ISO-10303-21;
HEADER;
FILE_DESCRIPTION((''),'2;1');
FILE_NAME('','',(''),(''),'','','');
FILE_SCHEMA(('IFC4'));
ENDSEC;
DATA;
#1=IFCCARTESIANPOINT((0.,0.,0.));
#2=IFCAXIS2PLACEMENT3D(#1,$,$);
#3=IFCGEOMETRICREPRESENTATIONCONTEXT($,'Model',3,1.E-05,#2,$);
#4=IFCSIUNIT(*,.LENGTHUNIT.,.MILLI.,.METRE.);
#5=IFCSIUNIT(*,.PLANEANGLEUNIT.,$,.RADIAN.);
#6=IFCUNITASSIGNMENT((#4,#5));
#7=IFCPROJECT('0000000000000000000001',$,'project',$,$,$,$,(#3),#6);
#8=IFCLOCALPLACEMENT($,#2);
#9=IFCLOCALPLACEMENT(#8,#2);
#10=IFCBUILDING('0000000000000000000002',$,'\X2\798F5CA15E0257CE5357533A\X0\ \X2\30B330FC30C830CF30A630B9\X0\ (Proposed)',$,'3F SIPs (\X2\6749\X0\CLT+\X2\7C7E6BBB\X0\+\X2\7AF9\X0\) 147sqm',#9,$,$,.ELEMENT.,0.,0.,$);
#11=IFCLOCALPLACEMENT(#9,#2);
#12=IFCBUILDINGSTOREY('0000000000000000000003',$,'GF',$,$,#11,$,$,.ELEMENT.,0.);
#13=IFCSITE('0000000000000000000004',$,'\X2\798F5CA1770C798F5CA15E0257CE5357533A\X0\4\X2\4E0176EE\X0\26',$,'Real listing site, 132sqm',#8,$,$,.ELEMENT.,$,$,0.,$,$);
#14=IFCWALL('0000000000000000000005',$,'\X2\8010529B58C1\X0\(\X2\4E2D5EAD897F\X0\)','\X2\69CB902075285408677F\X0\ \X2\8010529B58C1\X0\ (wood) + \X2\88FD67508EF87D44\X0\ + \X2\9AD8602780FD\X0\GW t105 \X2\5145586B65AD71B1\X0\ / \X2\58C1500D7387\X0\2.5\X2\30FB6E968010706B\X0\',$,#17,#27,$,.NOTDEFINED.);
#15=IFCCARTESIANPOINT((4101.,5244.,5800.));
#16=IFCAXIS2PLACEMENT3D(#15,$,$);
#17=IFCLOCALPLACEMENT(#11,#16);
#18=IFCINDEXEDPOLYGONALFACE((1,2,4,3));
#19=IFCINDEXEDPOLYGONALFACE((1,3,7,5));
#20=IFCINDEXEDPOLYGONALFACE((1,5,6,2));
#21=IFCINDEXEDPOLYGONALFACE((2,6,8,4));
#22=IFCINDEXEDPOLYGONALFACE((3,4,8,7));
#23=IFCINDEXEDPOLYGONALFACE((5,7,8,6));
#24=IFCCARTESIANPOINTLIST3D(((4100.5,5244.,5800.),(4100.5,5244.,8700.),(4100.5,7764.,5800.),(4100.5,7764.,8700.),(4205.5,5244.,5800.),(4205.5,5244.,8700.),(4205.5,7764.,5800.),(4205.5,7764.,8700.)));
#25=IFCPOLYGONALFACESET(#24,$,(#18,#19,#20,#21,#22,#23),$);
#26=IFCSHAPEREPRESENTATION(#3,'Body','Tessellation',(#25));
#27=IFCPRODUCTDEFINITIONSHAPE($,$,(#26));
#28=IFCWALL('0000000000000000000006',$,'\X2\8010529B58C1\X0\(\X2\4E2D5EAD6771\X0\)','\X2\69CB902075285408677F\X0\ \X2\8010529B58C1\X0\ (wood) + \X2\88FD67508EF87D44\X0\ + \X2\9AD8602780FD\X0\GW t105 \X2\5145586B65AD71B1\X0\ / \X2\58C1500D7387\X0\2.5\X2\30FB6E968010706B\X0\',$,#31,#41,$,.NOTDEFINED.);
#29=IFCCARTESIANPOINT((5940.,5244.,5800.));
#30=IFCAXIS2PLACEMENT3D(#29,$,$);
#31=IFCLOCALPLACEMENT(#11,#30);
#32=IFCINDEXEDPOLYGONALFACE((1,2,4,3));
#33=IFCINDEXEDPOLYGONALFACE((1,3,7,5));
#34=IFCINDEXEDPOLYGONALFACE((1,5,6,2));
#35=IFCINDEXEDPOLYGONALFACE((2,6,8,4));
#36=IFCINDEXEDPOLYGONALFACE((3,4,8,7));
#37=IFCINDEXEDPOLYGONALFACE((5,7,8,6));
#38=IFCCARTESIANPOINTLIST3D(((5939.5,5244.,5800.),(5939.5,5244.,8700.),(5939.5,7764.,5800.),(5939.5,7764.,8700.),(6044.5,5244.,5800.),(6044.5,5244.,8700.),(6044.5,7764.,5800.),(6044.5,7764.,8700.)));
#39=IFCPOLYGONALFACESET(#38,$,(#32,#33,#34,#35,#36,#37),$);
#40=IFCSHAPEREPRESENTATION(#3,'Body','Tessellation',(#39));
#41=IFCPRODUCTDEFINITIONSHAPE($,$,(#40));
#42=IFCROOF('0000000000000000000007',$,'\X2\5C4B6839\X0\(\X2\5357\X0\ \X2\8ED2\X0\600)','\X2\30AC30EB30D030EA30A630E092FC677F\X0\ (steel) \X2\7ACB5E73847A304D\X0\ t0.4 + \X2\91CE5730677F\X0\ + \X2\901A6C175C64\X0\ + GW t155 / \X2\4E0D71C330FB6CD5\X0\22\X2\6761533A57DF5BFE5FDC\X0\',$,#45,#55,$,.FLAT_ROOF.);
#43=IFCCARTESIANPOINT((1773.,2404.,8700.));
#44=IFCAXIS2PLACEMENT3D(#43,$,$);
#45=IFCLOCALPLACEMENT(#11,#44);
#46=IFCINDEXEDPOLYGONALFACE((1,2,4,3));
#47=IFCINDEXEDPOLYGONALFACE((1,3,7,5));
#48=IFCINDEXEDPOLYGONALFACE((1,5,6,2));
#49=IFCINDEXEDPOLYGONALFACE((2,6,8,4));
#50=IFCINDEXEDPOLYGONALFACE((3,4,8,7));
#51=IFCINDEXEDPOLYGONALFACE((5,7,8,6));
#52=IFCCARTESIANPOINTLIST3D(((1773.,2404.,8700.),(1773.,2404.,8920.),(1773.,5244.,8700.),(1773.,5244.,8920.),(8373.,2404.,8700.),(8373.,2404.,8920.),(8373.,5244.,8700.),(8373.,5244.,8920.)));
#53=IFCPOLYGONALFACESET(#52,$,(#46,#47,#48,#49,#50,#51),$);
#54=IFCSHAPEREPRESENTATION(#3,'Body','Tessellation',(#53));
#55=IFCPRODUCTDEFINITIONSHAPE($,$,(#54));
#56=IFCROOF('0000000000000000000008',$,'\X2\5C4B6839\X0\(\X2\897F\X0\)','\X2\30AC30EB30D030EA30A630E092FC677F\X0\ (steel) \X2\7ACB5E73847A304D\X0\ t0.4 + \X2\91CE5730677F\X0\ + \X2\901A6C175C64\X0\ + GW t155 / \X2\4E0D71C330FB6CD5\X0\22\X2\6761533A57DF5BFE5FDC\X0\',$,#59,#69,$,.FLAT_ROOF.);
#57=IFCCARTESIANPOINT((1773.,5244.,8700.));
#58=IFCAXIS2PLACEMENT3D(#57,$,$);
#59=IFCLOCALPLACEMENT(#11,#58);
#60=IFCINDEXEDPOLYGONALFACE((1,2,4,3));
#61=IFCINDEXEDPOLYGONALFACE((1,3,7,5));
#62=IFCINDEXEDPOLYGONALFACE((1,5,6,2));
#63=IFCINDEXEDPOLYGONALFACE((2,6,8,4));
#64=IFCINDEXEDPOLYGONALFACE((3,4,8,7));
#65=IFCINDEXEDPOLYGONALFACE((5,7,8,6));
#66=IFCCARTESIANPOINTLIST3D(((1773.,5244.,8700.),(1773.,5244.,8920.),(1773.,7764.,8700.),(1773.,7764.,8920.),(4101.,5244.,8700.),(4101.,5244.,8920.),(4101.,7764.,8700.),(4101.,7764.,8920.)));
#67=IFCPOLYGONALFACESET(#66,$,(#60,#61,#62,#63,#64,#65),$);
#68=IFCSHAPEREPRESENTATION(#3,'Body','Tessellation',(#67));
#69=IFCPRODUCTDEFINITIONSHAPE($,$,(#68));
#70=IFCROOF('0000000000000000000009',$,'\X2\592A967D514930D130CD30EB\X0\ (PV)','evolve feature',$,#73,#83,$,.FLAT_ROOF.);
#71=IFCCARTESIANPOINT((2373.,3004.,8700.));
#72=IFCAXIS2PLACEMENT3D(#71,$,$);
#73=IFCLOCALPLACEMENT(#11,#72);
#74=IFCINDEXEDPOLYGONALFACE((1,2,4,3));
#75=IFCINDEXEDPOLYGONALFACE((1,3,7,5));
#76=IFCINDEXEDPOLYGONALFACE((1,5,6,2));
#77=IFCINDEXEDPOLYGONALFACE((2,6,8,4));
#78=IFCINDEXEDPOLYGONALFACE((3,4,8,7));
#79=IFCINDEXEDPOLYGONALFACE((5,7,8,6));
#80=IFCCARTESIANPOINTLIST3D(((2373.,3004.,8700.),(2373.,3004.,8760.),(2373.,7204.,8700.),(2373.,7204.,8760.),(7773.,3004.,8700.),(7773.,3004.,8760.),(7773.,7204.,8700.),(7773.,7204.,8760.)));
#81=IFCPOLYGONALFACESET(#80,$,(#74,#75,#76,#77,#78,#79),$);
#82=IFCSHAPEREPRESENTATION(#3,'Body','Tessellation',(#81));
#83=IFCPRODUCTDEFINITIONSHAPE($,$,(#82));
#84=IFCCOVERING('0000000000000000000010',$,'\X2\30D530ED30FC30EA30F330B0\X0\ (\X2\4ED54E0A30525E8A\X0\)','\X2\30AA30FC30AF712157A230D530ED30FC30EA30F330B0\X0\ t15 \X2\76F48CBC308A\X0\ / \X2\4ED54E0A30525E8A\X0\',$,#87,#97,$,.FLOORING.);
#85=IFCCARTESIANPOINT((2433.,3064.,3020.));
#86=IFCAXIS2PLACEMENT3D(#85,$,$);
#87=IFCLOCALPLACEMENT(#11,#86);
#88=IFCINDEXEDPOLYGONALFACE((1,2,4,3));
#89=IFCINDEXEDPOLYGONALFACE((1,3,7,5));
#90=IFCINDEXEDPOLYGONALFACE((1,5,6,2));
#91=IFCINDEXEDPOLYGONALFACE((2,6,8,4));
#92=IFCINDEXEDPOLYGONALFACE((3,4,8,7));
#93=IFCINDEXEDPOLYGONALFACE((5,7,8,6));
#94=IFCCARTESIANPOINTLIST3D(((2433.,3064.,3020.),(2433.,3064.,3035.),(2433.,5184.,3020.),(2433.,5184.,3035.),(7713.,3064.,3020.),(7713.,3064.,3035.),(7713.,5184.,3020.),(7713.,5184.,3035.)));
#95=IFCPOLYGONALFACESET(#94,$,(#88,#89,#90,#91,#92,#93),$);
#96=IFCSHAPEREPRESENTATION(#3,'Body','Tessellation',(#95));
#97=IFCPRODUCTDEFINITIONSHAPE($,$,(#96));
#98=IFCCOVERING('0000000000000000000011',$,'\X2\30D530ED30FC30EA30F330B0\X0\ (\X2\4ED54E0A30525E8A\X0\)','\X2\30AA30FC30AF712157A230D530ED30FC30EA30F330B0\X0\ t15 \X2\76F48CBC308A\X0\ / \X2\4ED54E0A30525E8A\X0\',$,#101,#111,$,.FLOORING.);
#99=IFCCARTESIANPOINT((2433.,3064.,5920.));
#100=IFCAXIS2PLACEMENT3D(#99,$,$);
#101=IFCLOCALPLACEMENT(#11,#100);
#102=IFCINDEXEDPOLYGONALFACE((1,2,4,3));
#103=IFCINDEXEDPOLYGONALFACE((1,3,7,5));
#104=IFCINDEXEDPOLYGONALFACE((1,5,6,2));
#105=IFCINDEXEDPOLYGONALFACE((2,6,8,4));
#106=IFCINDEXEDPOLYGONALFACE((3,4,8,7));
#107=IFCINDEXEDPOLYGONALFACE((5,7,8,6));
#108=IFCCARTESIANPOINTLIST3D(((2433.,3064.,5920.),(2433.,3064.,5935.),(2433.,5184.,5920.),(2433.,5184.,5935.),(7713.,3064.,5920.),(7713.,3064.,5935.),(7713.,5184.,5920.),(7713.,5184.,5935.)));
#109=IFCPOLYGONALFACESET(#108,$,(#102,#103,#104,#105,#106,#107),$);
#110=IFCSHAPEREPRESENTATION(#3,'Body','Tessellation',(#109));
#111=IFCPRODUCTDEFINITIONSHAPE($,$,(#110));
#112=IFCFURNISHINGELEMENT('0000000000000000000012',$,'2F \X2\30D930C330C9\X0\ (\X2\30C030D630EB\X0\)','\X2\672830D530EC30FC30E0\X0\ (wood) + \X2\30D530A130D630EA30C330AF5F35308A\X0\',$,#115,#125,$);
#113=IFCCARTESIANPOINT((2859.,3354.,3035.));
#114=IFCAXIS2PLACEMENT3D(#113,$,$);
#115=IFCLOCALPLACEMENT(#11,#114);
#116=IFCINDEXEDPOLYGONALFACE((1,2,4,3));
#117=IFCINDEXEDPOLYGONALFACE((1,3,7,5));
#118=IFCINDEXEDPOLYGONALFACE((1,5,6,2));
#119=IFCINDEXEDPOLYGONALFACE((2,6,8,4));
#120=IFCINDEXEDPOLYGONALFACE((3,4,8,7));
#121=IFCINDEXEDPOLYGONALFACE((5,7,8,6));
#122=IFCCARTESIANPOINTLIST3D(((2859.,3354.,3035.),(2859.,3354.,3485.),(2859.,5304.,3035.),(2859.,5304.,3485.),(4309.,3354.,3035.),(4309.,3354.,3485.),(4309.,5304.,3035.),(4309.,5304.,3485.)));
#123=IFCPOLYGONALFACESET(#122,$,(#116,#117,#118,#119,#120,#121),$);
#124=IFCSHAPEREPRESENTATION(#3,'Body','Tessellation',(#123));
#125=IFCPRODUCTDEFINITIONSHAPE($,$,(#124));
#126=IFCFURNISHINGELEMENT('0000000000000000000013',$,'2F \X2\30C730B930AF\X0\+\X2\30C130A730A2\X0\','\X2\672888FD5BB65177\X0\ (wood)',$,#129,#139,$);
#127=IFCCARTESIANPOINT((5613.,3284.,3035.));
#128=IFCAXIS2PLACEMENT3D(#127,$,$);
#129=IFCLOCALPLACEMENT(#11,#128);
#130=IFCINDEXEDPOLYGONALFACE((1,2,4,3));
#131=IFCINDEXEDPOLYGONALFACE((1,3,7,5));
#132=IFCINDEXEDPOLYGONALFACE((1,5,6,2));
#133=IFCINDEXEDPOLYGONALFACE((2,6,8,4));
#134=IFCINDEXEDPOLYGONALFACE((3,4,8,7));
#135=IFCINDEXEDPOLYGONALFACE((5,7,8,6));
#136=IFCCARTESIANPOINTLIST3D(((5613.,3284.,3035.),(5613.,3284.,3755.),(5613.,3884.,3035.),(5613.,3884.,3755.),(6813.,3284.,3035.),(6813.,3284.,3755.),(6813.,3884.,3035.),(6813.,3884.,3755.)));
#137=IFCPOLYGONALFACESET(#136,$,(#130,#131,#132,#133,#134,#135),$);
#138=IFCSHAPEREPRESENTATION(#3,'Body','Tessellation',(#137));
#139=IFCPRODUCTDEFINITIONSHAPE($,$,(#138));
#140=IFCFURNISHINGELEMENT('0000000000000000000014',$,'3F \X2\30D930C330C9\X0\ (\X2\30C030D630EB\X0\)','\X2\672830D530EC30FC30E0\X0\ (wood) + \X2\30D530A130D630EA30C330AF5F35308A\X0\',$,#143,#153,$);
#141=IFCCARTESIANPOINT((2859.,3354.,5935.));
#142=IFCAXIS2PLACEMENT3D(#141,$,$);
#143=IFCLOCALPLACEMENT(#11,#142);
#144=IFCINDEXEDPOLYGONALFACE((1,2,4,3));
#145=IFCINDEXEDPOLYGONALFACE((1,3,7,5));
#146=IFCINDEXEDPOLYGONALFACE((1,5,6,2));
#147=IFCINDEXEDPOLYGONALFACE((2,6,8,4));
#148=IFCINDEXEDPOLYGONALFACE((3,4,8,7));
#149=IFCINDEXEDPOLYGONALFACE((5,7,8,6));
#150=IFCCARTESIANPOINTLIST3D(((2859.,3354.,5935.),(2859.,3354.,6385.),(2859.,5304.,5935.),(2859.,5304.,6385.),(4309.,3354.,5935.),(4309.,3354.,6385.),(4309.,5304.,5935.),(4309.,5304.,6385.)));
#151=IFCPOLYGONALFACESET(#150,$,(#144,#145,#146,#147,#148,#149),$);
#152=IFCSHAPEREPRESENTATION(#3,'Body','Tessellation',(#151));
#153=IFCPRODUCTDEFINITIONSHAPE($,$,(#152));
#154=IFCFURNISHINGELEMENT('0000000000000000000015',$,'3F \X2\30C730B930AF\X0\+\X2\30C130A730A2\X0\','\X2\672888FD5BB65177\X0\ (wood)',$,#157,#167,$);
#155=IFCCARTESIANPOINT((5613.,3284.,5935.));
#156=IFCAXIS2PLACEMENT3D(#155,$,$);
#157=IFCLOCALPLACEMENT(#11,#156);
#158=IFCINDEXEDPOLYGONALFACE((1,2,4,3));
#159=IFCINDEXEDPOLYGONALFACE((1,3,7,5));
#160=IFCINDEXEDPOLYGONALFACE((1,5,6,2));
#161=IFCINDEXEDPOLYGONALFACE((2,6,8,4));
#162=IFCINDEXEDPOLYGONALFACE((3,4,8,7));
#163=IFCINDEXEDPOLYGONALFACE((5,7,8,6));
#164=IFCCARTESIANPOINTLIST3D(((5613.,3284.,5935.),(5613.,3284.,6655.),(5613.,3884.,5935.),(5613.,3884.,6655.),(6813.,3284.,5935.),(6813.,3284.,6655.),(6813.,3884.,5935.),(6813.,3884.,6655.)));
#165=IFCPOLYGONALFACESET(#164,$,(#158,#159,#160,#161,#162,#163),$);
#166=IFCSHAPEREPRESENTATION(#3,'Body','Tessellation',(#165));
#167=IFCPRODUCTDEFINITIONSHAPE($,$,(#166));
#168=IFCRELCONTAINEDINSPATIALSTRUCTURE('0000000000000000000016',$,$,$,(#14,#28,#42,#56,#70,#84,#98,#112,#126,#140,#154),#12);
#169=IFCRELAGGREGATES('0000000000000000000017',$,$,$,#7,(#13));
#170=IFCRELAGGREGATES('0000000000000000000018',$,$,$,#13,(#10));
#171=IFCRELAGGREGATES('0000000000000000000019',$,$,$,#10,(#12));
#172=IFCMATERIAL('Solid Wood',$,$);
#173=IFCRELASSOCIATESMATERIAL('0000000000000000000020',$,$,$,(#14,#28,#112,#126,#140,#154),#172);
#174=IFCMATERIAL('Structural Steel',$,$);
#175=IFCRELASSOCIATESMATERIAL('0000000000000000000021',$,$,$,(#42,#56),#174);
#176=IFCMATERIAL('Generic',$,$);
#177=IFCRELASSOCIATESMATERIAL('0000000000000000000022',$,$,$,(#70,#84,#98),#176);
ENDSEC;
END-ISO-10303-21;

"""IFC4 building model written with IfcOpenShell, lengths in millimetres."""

from ifc_helpers import new_model, si_unit, frame, frame_2d, origin, place, context, project, spatial, rectangle, extrude, material, element, save


model = new_model("IFC4")

# Units and contexts
model_context = context("Model", 3, precision=1e-05, world=origin())
ifc_project = project(units=[si_unit("LENGTHUNIT", "METRE", prefix="MILLI"), si_unit("PLANEANGLEUNIT", "RADIAN")], contexts=[model_context])

# Site, building, storey
site_placement = place(None, origin())
site = spatial("IfcSite", under=ifc_project, at=site_placement, Name="福岡県福岡市城南区4丁目26", ObjectType="Real listing site, 132sqm", CompositionType="ELEMENT", RefElevation=0.0)
building_placement = place(site_placement, origin())
building = spatial("IfcBuilding", under=site, at=building_placement, Name="福岡市城南区 コートハウス (Proposed)", ObjectType="3F SIPs (杉CLT+籾殻+竹) 147sqm", CompositionType="ELEMENT", ElevationOfRefHeight=0.0, ElevationOfTerrain=0.0)
storey_placement = place(building_placement, origin())
storey = spatial("IfcBuildingStorey", under=building, at=storey_placement, Name="GF", CompositionType="ELEMENT", Elevation=0.0)

# Shared definitions
ifc_material_1 = material(Name="Solid Wood")

# Walls
wall_1_placement = place(storey_placement, frame((4101.0, 5244.0, 5800.0)))
element("IfcWall", 1, at=wall_1_placement, inside=storey, material=ifc_material_1, Name="耐力壁(中庭西)", Description="構造用合板 耐力壁 (wood) + 製材軸組 + 高性能GW t105 充填断熱 / 壁倍率2.5・準耐火", PredefinedType="NOTDEFINED", context=model_context, shape_type="SweptSolid", body=[
    extrude(rectangle(XDim=105.0, YDim=2520.0, at=frame_2d((52.0, 1260.0))), frame((4101.0, 5244.0, 5800.0)), (0.0, 0.0, 1.0), 2900.0),
])
wall_2_placement = place(storey_placement, frame((5940.0, 5244.0, 5800.0)))
element("IfcWall", 2, at=wall_2_placement, inside=storey, material=ifc_material_1, Name="耐力壁(中庭東)", Description="構造用合板 耐力壁 (wood) + 製材軸組 + 高性能GW t105 充填断熱 / 壁倍率2.5・準耐火", PredefinedType="NOTDEFINED", context=model_context, shape_type="SweptSolid", body=[
    extrude(rectangle(XDim=105.0, YDim=2520.0, at=frame_2d((52.0, 1260.0))), frame((5940.0, 5244.0, 5800.0)), (0.0, 0.0, 1.0), 2900.0),
])

# Roofs
ifc_material_2 = material(Name="Structural Steel")
roof_1_placement = place(storey_placement, frame((1773.0, 2404.0, 8700.0)))
element("IfcRoof", 3, at=roof_1_placement, inside=storey, material=ifc_material_2, Name="屋根(南 軒600)", Description="ガルバリウム鋼板 (steel) 立平葺き t0.4 + 野地板 + 通気層 + GW t155 / 不燃・法22条区域対応", PredefinedType="FLAT_ROOF", context=model_context, shape_type="SweptSolid", body=[
    extrude(rectangle(XDim=6600.0, YDim=2840.0, at=frame_2d((3300.0, 1420.0))), frame((1773.0, 2404.0, 8700.0)), (0.0, 0.0, 1.0), 220.0),
])
roof_2_placement = place(storey_placement, frame((1773.0, 5244.0, 8700.0)))
element("IfcRoof", 4, at=roof_2_placement, inside=storey, material=ifc_material_2, Name="屋根(西)", Description="ガルバリウム鋼板 (steel) 立平葺き t0.4 + 野地板 + 通気層 + GW t155 / 不燃・法22条区域対応", PredefinedType="FLAT_ROOF", context=model_context, shape_type="SweptSolid", body=[
    extrude(rectangle(XDim=2328.0, YDim=2520.0, at=frame_2d((1164.0, 1260.0))), frame((1773.0, 5244.0, 8700.0)), (0.0, 0.0, 1.0), 220.0),
])
ifc_material_3 = material(Name="Generic")
roof_3_placement = place(storey_placement, frame((2373.0, 3004.0, 8700.0)))
element("IfcRoof", 5, at=roof_3_placement, inside=storey, material=ifc_material_3, Name="太陽光パネル (PV)", Description="evolve feature", PredefinedType="FLAT_ROOF", context=model_context, shape_type="SweptSolid", body=[
    extrude(rectangle(XDim=5400.0, YDim=4200.0, at=frame_2d((2700.0, 2100.0))), frame((2373.0, 3004.0, 8700.0)), (0.0, 0.0, 1.0), 60.0),
])

# Coverings
covering_1_placement = place(storey_placement, frame((2433.0, 3064.0, 3020.0)))
element("IfcCovering", 6, at=covering_1_placement, inside=storey, material=ifc_material_3, Name="フローリング (仕上げ床)", Description="オーク無垢フローリング t15 直貼り / 仕上げ床", PredefinedType="FLOORING", context=model_context, shape_type="SweptSolid", body=[
    extrude(rectangle(XDim=5280.0, YDim=2120.0, at=frame_2d((2640.0, 1060.0))), frame((2433.0, 3064.0, 3020.0)), (0.0, 0.0, 1.0), 15.0),
])
covering_2_placement = place(storey_placement, frame((2433.0, 3064.0, 5920.0)))
element("IfcCovering", 7, at=covering_2_placement, inside=storey, material=ifc_material_3, Name="フローリング (仕上げ床)", Description="オーク無垢フローリング t15 直貼り / 仕上げ床", PredefinedType="FLOORING", context=model_context, shape_type="SweptSolid", body=[
    extrude(rectangle(XDim=5280.0, YDim=2120.0, at=frame_2d((2640.0, 1060.0))), frame((2433.0, 3064.0, 5920.0)), (0.0, 0.0, 1.0), 15.0),
])

# Furnishing elements
furnishing_1_placement = place(storey_placement, frame((2859.0, 3354.0, 3035.0)))
element("IfcFurnishingElement", 8, at=furnishing_1_placement, inside=storey, material=ifc_material_1, Name="2F ベッド (ダブル)", Description="木フレーム (wood) + ファブリック張り", context=model_context, shape_type="SweptSolid", body=[
    extrude(rectangle(XDim=1450.0, YDim=1950.0, at=frame_2d((725.0, 975.0))), frame((2859.0, 3354.0, 3035.0)), (0.0, 0.0, 1.0), 450.0),
])
furnishing_2_placement = place(storey_placement, frame((5613.0, 3284.0, 3035.0)))
element("IfcFurnishingElement", 9, at=furnishing_2_placement, inside=storey, material=ifc_material_1, Name="2F デスク+チェア", Description="木製家具 (wood)", context=model_context, shape_type="SweptSolid", body=[
    extrude(rectangle(XDim=1200.0, YDim=600.0, at=frame_2d((600.0, 300.0))), frame((5613.0, 3284.0, 3035.0)), (0.0, 0.0, 1.0), 720.0),
])
furnishing_3_placement = place(storey_placement, frame((2859.0, 3354.0, 5935.0)))
element("IfcFurnishingElement", 10, at=furnishing_3_placement, inside=storey, material=ifc_material_1, Name="3F ベッド (ダブル)", Description="木フレーム (wood) + ファブリック張り", context=model_context, shape_type="SweptSolid", body=[
    extrude(rectangle(XDim=1450.0, YDim=1950.0, at=frame_2d((725.0, 975.0))), frame((2859.0, 3354.0, 5935.0)), (0.0, 0.0, 1.0), 450.0),
])
furnishing_4_placement = place(storey_placement, frame((5613.0, 3284.0, 5935.0)))
element("IfcFurnishingElement", 11, at=furnishing_4_placement, inside=storey, material=ifc_material_1, Name="3F デスク+チェア", Description="木製家具 (wood)", context=model_context, shape_type="SweptSolid", body=[
    extrude(rectangle(XDim=1200.0, YDim=600.0, at=frame_2d((600.0, 300.0))), frame((5613.0, 3284.0, 5935.0)), (0.0, 0.0, 1.0), 720.0),
])

save(model, "model.ifc")
